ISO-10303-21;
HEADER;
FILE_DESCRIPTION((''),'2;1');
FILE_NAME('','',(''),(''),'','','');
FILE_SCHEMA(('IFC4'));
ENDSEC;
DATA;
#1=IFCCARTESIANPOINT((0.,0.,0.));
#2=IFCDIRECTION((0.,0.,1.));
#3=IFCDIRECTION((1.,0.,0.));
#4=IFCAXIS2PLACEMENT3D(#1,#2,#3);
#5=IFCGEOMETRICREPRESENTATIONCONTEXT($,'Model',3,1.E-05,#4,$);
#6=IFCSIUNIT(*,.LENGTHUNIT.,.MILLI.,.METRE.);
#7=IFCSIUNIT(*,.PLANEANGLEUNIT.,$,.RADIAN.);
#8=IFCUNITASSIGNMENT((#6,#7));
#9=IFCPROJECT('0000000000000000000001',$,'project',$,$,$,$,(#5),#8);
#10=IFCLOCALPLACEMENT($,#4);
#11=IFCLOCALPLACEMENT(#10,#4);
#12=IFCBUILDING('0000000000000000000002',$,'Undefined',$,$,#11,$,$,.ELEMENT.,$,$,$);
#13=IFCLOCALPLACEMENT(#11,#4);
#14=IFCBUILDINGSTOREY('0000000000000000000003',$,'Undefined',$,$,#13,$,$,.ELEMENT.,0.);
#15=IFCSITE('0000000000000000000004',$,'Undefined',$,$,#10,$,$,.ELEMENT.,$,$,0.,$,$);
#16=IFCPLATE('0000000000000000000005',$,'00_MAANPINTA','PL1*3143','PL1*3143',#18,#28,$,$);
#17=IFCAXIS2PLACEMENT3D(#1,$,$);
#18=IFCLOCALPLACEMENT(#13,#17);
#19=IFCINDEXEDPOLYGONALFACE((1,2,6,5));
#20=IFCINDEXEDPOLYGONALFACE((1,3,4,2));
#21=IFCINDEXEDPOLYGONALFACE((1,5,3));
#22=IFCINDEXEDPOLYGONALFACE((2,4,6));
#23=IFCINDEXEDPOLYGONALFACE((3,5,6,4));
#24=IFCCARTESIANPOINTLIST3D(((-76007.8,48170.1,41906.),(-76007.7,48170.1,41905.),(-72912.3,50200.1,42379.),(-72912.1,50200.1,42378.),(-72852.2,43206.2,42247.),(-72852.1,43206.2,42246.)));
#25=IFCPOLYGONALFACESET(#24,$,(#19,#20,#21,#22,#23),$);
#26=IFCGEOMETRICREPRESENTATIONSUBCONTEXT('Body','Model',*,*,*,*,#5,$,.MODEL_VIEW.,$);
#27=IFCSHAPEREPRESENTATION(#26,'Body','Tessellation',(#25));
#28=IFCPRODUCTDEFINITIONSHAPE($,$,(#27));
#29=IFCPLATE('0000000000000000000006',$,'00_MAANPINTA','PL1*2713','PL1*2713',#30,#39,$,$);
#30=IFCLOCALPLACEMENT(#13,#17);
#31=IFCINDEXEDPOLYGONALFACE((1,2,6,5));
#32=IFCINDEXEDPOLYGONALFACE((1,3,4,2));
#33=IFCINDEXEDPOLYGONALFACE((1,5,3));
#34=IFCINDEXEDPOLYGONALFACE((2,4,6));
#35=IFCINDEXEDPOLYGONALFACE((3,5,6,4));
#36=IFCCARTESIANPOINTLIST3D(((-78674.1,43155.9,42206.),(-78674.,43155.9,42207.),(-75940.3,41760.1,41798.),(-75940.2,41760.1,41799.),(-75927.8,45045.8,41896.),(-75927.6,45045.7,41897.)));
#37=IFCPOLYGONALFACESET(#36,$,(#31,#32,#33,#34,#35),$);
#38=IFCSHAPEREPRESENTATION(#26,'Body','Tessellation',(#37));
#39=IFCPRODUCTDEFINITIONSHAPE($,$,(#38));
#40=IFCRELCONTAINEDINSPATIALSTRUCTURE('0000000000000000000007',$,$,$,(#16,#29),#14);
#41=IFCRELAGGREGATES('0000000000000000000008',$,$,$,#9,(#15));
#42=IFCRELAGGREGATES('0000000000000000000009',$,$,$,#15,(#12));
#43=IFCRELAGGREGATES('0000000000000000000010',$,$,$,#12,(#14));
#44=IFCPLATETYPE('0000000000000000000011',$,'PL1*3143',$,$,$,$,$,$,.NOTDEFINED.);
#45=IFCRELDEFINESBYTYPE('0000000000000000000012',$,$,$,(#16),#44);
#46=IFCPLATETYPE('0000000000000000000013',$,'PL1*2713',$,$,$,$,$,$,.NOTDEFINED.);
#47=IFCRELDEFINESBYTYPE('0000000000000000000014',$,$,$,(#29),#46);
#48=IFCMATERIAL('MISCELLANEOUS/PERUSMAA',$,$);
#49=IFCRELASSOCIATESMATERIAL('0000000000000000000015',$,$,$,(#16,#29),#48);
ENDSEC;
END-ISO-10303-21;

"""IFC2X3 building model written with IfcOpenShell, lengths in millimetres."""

from ifc_helpers import new_model, si_unit, frame, origin_with_axes, place, context, subcontext, project, spatial, polyline, outline, extrude, material, type_object, element, save


model = new_model("IFC2X3")

# Units and contexts
model_context = context("Model", 3, precision=1e-05, world=origin_with_axes())
body_context = subcontext(model_context, "Body", "Model", "MODEL_VIEW")
ifc_project = project(units=[si_unit("LENGTHUNIT", "METRE", prefix="MILLI"), si_unit("PLANEANGLEUNIT", "RADIAN")], contexts=[model_context])

# Site, building, storey
site_placement = place(None, origin_with_axes())
site = spatial("IfcSite", under=ifc_project, at=site_placement, Name="Undefined", CompositionType="ELEMENT", RefElevation=0.0)
building_placement = place(site_placement, origin_with_axes())
building = spatial("IfcBuilding", under=site, at=building_placement, Name="Undefined", CompositionType="ELEMENT")
storey_placement = place(building_placement, origin_with_axes())
storey = spatial("IfcBuildingStorey", under=building, at=storey_placement, Name="Undefined", CompositionType="ELEMENT", Elevation=0.0)

# Plates
ifc_material = material(Name="MISCELLANEOUS/PERUSMAA")
plate_type_1 = type_object("IfcPlateType", Name="PL1*3143", PredefinedType="NOTDEFINED")
plate_1_placement = place(storey_placement, frame((-72852.1, 43206.2, 42246.5), z_axis=(0.138269, 0.019876, -0.990195), x_axis=(-0.535581, 0.842498, -0.057876)))
element("IfcPlate", 1, at=plate_1_placement, inside=storey, type_object=plate_type_1, material=ifc_material, Name="00_MAANPINTA", Description="PL1*3143", ObjectType="PL1*3143", context=body_context, shape_type="SweptSolid", body=[
    extrude(outline(polyline([(0.0, 0.0), (5891.9, 0.0), (5916.9, 3731.8), (0.0, 0.0)])), frame((0.0, 0.0, -0.5), z_axis=(0.0, 0.0, 1.0), x_axis=(1.0, 0.0, 0.0)), (0.0, 0.0, 1.0), 1.0),
])
plate_type_2 = type_object("IfcPlateType", Name="PL1*2713", PredefinedType="NOTDEFINED")
plate_2_placement = place(storey_placement, frame((-78674.1, 43155.9, 42206.5), z_axis=(-0.132512, 0.030056, -0.990726), x_axis=(0.820261, 0.564446, -0.092588)))
element("IfcPlate", 2, at=plate_2_placement, inside=storey, type_object=plate_type_2, material=ifc_material, Name="00_MAANPINTA", Description="PL1*2713", ObjectType="PL1*2713", context=body_context, shape_type="SweptSolid", body=[
    extrude(outline(polyline([(0.0, 0.0), (3348.2, 0.0), (1492.4, 2713.2), (0.0, 0.0)])), frame((0.0, 0.0, -0.5), z_axis=(0.0, 0.0, 1.0), x_axis=(1.0, 0.0, 0.0)), (0.0, 0.0, 1.0), 1.0),
])

save(model, "model.ifc")
